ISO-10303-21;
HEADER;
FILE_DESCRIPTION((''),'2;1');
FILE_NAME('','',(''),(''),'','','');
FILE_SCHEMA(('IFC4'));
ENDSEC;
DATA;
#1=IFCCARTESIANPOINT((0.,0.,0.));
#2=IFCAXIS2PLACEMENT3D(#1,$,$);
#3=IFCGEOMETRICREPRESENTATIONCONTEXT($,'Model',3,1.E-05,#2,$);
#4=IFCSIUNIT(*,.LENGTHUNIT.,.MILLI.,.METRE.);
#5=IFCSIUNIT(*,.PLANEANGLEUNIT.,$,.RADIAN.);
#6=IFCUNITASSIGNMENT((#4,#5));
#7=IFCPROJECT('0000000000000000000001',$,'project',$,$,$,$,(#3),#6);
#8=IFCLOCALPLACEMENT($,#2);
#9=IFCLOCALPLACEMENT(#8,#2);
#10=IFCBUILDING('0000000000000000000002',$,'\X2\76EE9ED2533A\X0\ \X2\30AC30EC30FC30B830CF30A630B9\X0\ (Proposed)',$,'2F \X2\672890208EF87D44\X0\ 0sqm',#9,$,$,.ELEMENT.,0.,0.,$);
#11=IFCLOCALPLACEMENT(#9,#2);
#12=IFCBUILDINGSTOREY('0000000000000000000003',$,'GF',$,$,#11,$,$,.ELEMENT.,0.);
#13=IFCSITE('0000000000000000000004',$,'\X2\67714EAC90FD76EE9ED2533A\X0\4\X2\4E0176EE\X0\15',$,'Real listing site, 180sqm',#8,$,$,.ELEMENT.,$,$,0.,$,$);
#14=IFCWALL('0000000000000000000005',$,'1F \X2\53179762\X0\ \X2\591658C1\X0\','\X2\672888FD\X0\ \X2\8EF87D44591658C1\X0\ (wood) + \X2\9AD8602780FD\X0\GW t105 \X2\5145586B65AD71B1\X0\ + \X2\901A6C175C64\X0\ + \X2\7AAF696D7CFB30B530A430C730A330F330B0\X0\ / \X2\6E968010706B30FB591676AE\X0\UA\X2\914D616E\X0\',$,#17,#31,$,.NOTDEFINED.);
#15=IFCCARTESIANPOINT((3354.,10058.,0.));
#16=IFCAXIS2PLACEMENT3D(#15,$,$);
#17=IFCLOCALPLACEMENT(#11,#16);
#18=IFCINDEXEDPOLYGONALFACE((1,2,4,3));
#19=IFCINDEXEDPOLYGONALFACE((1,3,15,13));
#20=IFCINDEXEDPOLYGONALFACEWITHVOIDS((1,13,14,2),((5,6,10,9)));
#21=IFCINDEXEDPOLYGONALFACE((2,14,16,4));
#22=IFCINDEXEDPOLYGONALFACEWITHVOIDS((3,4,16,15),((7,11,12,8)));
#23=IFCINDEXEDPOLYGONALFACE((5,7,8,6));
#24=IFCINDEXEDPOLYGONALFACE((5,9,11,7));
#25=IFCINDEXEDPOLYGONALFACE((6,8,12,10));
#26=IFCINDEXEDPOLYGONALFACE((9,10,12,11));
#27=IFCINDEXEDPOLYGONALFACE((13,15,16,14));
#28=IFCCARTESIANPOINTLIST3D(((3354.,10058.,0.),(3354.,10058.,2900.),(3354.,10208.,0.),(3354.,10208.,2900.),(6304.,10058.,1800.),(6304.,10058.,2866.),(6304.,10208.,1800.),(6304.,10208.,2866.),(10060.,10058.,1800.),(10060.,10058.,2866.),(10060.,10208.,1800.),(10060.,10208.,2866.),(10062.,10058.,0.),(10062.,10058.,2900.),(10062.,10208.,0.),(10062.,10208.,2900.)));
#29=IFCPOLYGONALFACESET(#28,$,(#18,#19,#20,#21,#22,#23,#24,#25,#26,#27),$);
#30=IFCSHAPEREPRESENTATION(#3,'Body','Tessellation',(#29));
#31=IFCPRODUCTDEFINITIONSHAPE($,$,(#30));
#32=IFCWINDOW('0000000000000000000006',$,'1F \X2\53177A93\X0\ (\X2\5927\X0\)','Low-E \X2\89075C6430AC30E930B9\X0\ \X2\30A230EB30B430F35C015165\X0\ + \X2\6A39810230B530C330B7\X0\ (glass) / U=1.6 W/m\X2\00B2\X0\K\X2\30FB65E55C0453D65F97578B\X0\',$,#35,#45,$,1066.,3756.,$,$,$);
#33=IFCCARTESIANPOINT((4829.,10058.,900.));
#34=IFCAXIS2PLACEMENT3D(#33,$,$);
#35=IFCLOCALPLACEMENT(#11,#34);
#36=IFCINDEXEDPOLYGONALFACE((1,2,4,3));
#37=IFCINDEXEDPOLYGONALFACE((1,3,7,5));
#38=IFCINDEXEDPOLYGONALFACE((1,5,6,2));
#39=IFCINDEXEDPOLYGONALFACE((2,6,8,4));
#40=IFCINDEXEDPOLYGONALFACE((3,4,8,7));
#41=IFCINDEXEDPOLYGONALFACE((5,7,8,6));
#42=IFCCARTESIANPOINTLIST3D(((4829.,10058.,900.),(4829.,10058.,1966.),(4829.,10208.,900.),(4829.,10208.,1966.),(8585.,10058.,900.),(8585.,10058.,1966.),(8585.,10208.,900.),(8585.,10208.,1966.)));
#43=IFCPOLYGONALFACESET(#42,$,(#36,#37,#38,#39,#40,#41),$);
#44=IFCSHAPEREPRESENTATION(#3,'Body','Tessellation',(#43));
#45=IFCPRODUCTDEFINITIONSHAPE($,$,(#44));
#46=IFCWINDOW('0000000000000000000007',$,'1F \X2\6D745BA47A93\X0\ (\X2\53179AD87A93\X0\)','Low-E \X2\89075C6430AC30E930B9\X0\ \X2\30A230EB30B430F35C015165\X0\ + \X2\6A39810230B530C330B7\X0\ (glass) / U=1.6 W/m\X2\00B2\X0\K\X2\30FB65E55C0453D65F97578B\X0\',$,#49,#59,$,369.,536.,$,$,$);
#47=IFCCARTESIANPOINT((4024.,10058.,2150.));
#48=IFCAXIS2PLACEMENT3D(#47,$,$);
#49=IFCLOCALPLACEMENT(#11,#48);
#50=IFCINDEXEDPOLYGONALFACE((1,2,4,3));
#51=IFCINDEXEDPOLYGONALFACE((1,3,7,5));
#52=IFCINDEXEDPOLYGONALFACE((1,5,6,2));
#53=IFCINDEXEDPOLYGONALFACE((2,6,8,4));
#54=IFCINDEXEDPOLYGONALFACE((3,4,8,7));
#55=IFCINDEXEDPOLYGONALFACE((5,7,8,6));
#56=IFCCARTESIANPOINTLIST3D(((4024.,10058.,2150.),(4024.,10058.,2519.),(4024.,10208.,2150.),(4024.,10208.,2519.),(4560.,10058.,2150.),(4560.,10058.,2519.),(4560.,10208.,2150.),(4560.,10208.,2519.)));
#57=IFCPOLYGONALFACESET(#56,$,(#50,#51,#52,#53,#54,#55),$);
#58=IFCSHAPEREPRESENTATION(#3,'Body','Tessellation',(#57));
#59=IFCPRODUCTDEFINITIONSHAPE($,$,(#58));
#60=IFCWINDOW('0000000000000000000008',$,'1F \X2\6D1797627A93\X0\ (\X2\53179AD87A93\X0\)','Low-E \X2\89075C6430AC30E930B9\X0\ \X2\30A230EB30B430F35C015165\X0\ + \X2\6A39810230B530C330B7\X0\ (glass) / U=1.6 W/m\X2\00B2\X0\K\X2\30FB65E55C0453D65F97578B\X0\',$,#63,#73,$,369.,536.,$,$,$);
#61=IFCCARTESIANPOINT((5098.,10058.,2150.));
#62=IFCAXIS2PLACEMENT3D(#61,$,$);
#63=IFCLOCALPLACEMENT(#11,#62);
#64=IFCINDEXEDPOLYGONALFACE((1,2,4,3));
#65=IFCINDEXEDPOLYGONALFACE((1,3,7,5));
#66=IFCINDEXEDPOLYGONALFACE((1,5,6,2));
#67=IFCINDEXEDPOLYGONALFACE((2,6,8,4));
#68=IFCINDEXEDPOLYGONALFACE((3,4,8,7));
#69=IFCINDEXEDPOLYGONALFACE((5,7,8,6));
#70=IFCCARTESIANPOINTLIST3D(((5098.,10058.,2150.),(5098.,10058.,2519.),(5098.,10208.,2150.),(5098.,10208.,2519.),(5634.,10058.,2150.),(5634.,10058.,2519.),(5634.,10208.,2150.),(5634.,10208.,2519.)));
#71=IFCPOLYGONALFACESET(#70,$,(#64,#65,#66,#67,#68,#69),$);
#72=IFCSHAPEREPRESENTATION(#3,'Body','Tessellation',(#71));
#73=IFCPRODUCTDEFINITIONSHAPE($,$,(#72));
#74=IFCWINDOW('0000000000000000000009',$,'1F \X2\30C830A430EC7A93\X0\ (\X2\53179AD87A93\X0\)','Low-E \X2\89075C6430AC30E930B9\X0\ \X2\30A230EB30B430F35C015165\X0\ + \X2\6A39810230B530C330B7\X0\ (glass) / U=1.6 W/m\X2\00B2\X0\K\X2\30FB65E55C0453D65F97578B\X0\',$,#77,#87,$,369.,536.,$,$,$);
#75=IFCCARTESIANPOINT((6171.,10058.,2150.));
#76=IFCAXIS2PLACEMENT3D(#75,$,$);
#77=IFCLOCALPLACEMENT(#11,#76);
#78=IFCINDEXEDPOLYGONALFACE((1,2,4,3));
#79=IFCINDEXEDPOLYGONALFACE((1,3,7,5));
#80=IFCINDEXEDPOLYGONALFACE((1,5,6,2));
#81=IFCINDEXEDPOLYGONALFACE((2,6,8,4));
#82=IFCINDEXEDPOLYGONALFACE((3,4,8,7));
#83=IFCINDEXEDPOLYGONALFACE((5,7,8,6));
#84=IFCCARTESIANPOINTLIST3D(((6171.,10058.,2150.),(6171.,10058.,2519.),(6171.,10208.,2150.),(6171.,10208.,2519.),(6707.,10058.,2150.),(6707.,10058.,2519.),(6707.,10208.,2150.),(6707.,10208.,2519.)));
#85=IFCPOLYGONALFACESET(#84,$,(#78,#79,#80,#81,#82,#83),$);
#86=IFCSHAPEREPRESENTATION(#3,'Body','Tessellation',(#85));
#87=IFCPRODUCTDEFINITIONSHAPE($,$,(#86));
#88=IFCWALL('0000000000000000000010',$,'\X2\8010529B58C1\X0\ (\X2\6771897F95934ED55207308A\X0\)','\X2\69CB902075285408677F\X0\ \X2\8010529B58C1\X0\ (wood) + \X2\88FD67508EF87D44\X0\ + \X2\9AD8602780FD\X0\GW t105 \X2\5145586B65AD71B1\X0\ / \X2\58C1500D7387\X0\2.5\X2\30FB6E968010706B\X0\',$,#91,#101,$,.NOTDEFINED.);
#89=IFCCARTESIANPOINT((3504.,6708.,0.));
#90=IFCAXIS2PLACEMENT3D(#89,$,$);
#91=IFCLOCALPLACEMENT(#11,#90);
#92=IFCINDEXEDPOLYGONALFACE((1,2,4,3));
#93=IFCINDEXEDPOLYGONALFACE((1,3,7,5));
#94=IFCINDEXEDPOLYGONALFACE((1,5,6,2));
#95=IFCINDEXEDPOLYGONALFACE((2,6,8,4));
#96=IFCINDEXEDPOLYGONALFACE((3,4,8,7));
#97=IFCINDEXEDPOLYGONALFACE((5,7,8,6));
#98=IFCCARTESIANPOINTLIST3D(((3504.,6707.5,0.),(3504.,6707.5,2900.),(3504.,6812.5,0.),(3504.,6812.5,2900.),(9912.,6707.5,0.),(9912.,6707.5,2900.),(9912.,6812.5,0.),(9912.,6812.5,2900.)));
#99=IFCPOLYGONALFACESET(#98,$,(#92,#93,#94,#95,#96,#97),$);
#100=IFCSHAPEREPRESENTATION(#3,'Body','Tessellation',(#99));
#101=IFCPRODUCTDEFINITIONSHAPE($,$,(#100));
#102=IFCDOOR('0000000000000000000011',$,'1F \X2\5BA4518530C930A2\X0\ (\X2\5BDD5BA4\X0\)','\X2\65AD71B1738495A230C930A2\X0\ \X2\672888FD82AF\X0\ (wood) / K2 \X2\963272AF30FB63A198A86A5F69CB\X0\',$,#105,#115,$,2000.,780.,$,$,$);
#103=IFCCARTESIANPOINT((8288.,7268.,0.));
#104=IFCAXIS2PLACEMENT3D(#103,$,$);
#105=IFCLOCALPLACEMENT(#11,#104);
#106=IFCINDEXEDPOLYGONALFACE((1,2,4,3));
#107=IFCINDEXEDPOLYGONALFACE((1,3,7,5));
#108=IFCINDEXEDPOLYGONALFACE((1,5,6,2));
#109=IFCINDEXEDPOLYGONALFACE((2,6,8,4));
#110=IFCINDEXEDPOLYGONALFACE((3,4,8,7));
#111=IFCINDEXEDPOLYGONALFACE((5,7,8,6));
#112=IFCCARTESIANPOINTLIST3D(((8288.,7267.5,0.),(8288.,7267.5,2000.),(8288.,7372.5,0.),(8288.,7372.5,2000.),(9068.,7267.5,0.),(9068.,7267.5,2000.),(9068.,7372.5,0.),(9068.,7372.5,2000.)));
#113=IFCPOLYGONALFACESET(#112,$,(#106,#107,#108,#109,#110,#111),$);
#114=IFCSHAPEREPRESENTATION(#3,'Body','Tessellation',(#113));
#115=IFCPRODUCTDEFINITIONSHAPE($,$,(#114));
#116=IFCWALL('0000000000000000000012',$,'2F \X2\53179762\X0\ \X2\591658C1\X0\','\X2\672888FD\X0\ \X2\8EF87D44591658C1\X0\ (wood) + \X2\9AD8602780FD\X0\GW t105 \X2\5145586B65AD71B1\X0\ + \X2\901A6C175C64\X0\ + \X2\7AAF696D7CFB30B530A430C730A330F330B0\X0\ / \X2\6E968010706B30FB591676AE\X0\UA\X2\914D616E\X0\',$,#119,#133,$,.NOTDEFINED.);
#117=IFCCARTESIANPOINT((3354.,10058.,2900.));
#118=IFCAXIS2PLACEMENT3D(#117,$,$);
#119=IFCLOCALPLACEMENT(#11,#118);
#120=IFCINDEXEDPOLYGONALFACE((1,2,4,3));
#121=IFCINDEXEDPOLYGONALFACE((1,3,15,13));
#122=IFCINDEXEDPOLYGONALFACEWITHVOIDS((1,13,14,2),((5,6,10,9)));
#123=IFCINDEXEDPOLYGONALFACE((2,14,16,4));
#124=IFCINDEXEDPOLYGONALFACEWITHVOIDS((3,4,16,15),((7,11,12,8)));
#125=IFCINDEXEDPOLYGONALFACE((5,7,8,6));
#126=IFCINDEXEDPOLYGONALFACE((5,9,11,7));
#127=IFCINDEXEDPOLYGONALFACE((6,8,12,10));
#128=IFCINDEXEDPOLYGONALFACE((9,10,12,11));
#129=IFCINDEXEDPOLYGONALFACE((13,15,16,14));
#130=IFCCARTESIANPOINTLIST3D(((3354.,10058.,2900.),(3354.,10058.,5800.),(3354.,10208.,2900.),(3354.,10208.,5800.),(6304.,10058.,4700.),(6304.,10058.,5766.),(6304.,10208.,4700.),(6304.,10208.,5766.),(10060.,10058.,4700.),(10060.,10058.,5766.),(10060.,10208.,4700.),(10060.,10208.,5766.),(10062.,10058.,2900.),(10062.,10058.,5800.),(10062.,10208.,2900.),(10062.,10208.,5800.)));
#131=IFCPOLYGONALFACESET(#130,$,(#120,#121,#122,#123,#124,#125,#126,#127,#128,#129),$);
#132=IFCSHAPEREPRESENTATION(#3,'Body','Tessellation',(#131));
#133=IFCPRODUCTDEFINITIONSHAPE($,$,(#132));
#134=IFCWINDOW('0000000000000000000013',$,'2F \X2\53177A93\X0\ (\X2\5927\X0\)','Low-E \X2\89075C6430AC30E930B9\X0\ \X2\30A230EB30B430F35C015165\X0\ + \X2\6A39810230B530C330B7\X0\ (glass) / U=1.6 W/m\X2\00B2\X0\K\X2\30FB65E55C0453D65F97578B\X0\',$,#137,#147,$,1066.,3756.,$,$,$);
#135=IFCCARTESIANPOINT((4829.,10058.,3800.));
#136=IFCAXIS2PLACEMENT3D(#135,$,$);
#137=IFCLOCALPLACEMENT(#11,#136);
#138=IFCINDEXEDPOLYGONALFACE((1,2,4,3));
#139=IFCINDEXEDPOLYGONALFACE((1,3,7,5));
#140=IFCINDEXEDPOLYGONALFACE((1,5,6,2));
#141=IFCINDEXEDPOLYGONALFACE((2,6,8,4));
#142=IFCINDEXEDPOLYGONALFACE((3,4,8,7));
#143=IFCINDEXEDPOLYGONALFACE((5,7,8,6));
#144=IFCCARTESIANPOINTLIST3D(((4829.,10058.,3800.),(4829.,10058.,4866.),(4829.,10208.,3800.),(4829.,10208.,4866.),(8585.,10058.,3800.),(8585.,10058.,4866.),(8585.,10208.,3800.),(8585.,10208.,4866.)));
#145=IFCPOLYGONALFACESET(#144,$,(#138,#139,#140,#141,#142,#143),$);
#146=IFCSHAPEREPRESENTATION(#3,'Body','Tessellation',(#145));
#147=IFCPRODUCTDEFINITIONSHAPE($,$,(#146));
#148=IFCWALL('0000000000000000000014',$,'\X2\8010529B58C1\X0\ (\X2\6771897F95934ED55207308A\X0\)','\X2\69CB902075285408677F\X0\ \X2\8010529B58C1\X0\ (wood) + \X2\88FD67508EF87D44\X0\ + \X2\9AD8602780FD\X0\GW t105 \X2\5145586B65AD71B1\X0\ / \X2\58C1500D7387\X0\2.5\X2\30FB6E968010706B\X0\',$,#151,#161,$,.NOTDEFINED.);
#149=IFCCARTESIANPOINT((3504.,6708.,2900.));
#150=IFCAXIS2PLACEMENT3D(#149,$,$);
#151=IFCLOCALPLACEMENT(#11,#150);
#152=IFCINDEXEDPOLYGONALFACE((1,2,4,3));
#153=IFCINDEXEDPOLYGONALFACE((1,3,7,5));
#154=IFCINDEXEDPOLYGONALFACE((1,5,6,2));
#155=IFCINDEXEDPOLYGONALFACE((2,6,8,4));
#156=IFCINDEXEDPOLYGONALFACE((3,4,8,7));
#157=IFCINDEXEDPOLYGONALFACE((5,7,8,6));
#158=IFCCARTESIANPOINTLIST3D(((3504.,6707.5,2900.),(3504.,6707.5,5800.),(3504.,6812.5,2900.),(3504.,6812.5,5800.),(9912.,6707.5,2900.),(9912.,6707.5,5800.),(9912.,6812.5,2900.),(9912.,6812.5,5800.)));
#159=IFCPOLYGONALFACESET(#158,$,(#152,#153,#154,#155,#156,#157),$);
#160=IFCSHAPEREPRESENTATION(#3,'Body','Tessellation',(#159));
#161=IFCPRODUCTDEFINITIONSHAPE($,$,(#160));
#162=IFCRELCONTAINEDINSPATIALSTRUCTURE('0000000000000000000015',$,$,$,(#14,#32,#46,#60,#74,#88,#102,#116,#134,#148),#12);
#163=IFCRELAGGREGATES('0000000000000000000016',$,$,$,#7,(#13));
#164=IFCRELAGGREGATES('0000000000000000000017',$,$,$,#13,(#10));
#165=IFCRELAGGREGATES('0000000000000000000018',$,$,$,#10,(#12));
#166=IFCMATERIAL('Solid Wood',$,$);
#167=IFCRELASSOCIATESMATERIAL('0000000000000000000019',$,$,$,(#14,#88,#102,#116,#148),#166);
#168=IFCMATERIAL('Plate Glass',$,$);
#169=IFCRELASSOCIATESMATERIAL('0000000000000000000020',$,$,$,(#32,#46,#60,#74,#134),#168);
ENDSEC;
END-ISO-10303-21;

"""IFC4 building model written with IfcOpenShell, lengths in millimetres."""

from ifc_helpers import new_model, si_unit, frame, frame_2d, origin, place, context, project, spatial, rectangle, extrude, material, element, fill, save


model = new_model("IFC4")

# Units and contexts
model_context = context("Model", 3, precision=1e-05, world=origin())
ifc_project = project(units=[si_unit("LENGTHUNIT", "METRE", prefix="MILLI"), si_unit("PLANEANGLEUNIT", "RADIAN")], contexts=[model_context])

# Site, building, storey
site_placement = place(None, origin())
site = spatial("IfcSite", under=ifc_project, at=site_placement, Name="東京都目黒区4丁目15", ObjectType="Real listing site, 180sqm", CompositionType="ELEMENT", RefElevation=0.0)
building_placement = place(site_placement, origin())
building = spatial("IfcBuilding", under=site, at=building_placement, Name="目黒区 ガレージハウス (Proposed)", ObjectType="2F 木造軸組 0sqm", CompositionType="ELEMENT", ElevationOfRefHeight=0.0, ElevationOfTerrain=0.0)
storey_placement = place(building_placement, origin())
storey = spatial("IfcBuildingStorey", under=building, at=storey_placement, Name="GF", CompositionType="ELEMENT", Elevation=0.0)

# Wall, openings, windows
ifc_material_1 = material(Name="Solid Wood")
wall_1_placement = place(storey_placement, frame((3354.0, 10058.0, 0.0)))
wall_1 = element("IfcWall", 1, at=wall_1_placement, inside=storey, material=ifc_material_1, Name="1F 北面 外壁", Description="木製 軸組外壁 (wood) + 高性能GW t105 充填断熱 + 通気層 + 窯業系サイディング / 準耐火・外皮UA配慮", PredefinedType="NOTDEFINED", context=model_context, shape_type="SweptSolid", body=[
    extrude(rectangle(XDim=6708.0, YDim=150.0, at=frame_2d((3354.0, 75.0))), frame((3354.0, 10058.0, 0.0)), (0.0, 0.0, 1.0), 2900.0),
])
opening_1_placement = place(storey_placement, frame((4829.0, 10058.0, 900.0)))
opening_1 = element("IfcOpeningElement", 2, at=opening_1_placement, cuts=wall_1, PredefinedType="NOTDEFINED", context=model_context, shape_type="SweptSolid", body=[
    extrude(rectangle(XDim=3756.0, YDim=150.0, at=frame_2d((1878.0, 75.0))), frame((4829.0, 10058.0, 900.0)), (0.0, 0.0, 1.0), 1066.0),
])
opening_2_placement = place(storey_placement, frame((4024.0, 10058.0, 2150.0)))
opening_2 = element("IfcOpeningElement", 3, at=opening_2_placement, cuts=wall_1, PredefinedType="NOTDEFINED", context=model_context, shape_type="SweptSolid", body=[
    extrude(rectangle(XDim=536.0, YDim=150.0, at=frame_2d((268.0, 75.0))), frame((4024.0, 10058.0, 2150.0)), (0.0, 0.0, 1.0), 369.0),
])
opening_3_placement = place(storey_placement, frame((5098.0, 10058.0, 2150.0)))
opening_3 = element("IfcOpeningElement", 4, at=opening_3_placement, cuts=wall_1, PredefinedType="NOTDEFINED", context=model_context, shape_type="SweptSolid", body=[
    extrude(rectangle(XDim=536.0, YDim=150.0, at=frame_2d((268.0, 75.0))), frame((5098.0, 10058.0, 2150.0)), (0.0, 0.0, 1.0), 369.0),
])
opening_4_placement = place(storey_placement, frame((6171.0, 10058.0, 2150.0)))
opening_4 = element("IfcOpeningElement", 5, at=opening_4_placement, cuts=wall_1, PredefinedType="NOTDEFINED", context=model_context, shape_type="SweptSolid", body=[
    extrude(rectangle(XDim=536.0, YDim=150.0, at=frame_2d((268.0, 75.0))), frame((6171.0, 10058.0, 2150.0)), (0.0, 0.0, 1.0), 369.0),
])
ifc_material_2 = material(Name="Plate Glass")
window_1_placement = place(storey_placement, frame((4829.0, 10058.0, 900.0)))
window_1 = element("IfcWindow", 6, at=window_1_placement, inside=storey, material=ifc_material_2, Name="1F 北窓 (大)", Description="Low-E 複層ガラス アルゴン封入 + 樹脂サッシ (glass) / U=1.6 W/m²K・日射取得型", OverallHeight=1066.0, OverallWidth=3756.0, context=model_context, shape_type="SweptSolid", body=[
    extrude(rectangle(XDim=3756.0, YDim=150.0, at=frame_2d((1878.0, 75.0))), frame((4829.0, 10058.0, 900.0)), (0.0, 0.0, 1.0), 1066.0),
])
fill(opening_1, window_1)
window_2_placement = place(storey_placement, frame((4024.0, 10058.0, 2150.0)))
window_2 = element("IfcWindow", 7, at=window_2_placement, inside=storey, material=ifc_material_2, Name="1F 浴室窓 (北高窓)", Description="Low-E 複層ガラス アルゴン封入 + 樹脂サッシ (glass) / U=1.6 W/m²K・日射取得型", OverallHeight=369.0, OverallWidth=536.0, context=model_context, shape_type="SweptSolid", body=[
    extrude(rectangle(XDim=536.0, YDim=150.0, at=frame_2d((268.0, 75.0))), frame((4024.0, 10058.0, 2150.0)), (0.0, 0.0, 1.0), 369.0),
])
fill(opening_2, window_2)
window_3_placement = place(storey_placement, frame((5098.0, 10058.0, 2150.0)))
window_3 = element("IfcWindow", 8, at=window_3_placement, inside=storey, material=ifc_material_2, Name="1F 洗面窓 (北高窓)", Description="Low-E 複層ガラス アルゴン封入 + 樹脂サッシ (glass) / U=1.6 W/m²K・日射取得型", OverallHeight=369.0, OverallWidth=536.0, context=model_context, shape_type="SweptSolid", body=[
    extrude(rectangle(XDim=536.0, YDim=150.0, at=frame_2d((268.0, 75.0))), frame((5098.0, 10058.0, 2150.0)), (0.0, 0.0, 1.0), 369.0),
])
fill(opening_3, window_3)
window_4_placement = place(storey_placement, frame((6171.0, 10058.0, 2150.0)))
window_4 = element("IfcWindow", 9, at=window_4_placement, inside=storey, material=ifc_material_2, Name="1F トイレ窓 (北高窓)", Description="Low-E 複層ガラス アルゴン封入 + 樹脂サッシ (glass) / U=1.6 W/m²K・日射取得型", OverallHeight=369.0, OverallWidth=536.0, context=model_context, shape_type="SweptSolid", body=[
    extrude(rectangle(XDim=536.0, YDim=150.0, at=frame_2d((268.0, 75.0))), frame((6171.0, 10058.0, 2150.0)), (0.0, 0.0, 1.0), 369.0),
])
fill(opening_4, window_4)

# Wall
wall_2_placement = place(storey_placement, frame((3504.0, 6708.0, 0.0)))
element("IfcWall", 10, at=wall_2_placement, inside=storey, material=ifc_material_1, Name="耐力壁 (東西間仕切り)", Description="構造用合板 耐力壁 (wood) + 製材軸組 + 高性能GW t105 充填断熱 / 壁倍率2.5・準耐火", PredefinedType="NOTDEFINED", context=model_context, shape_type="SweptSolid", body=[
    extrude(rectangle(XDim=6408.0, YDim=105.0, at=frame_2d((3204.0, 52.0))), frame((3504.0, 6708.0, 0.0)), (0.0, 0.0, 1.0), 2900.0),
])

# Door
door_1_placement = place(storey_placement, frame((8288.0, 7268.0, 0.0)))
element("IfcDoor", 11, at=door_1_placement, inside=storey, material=ifc_material_1, Name="1F 室内ドア (寝室)", Description="断熱玄関ドア 木製芯 (wood) / K2 防犯・採風機構", OverallHeight=2000.0, OverallWidth=780.0, context=model_context, shape_type="SweptSolid", body=[
    extrude(rectangle(XDim=780.0, YDim=105.0, at=frame_2d((390.0, 52.0))), frame((8288.0, 7268.0, 0.0)), (0.0, 0.0, 1.0), 2000.0),
])

# Wall, opening, window
wall_3_placement = place(storey_placement, frame((3354.0, 10058.0, 2900.0)))
wall_3 = element("IfcWall", 12, at=wall_3_placement, inside=storey, material=ifc_material_1, Name="2F 北面 外壁", Description="木製 軸組外壁 (wood) + 高性能GW t105 充填断熱 + 通気層 + 窯業系サイディング / 準耐火・外皮UA配慮", PredefinedType="NOTDEFINED", context=model_context, shape_type="SweptSolid", body=[
    extrude(rectangle(XDim=6708.0, YDim=150.0, at=frame_2d((3354.0, 75.0))), frame((3354.0, 10058.0, 2900.0)), (0.0, 0.0, 1.0), 2900.0),
])
opening_5_placement = place(storey_placement, frame((4829.0, 10058.0, 3800.0)))
opening_5 = element("IfcOpeningElement", 13, at=opening_5_placement, cuts=wall_3, PredefinedType="NOTDEFINED", context=model_context, shape_type="SweptSolid", body=[
    extrude(rectangle(XDim=3756.0, YDim=150.0, at=frame_2d((1878.0, 75.0))), frame((4829.0, 10058.0, 3800.0)), (0.0, 0.0, 1.0), 1066.0),
])
window_5_placement = place(storey_placement, frame((4829.0, 10058.0, 3800.0)))
window_5 = element("IfcWindow", 14, at=window_5_placement, inside=storey, material=ifc_material_2, Name="2F 北窓 (大)", Description="Low-E 複層ガラス アルゴン封入 + 樹脂サッシ (glass) / U=1.6 W/m²K・日射取得型", OverallHeight=1066.0, OverallWidth=3756.0, context=model_context, shape_type="SweptSolid", body=[
    extrude(rectangle(XDim=3756.0, YDim=150.0, at=frame_2d((1878.0, 75.0))), frame((4829.0, 10058.0, 3800.0)), (0.0, 0.0, 1.0), 1066.0),
])
fill(opening_5, window_5)

# Wall
wall_4_placement = place(storey_placement, frame((3504.0, 6708.0, 2900.0)))
element("IfcWall", 15, at=wall_4_placement, inside=storey, material=ifc_material_1, Name="耐力壁 (東西間仕切り)", Description="構造用合板 耐力壁 (wood) + 製材軸組 + 高性能GW t105 充填断熱 / 壁倍率2.5・準耐火", PredefinedType="NOTDEFINED", context=model_context, shape_type="SweptSolid", body=[
    extrude(rectangle(XDim=6408.0, YDim=105.0, at=frame_2d((3204.0, 52.0))), frame((3504.0, 6708.0, 2900.0)), (0.0, 0.0, 1.0), 2900.0),
])

save(model, "model.ifc")
